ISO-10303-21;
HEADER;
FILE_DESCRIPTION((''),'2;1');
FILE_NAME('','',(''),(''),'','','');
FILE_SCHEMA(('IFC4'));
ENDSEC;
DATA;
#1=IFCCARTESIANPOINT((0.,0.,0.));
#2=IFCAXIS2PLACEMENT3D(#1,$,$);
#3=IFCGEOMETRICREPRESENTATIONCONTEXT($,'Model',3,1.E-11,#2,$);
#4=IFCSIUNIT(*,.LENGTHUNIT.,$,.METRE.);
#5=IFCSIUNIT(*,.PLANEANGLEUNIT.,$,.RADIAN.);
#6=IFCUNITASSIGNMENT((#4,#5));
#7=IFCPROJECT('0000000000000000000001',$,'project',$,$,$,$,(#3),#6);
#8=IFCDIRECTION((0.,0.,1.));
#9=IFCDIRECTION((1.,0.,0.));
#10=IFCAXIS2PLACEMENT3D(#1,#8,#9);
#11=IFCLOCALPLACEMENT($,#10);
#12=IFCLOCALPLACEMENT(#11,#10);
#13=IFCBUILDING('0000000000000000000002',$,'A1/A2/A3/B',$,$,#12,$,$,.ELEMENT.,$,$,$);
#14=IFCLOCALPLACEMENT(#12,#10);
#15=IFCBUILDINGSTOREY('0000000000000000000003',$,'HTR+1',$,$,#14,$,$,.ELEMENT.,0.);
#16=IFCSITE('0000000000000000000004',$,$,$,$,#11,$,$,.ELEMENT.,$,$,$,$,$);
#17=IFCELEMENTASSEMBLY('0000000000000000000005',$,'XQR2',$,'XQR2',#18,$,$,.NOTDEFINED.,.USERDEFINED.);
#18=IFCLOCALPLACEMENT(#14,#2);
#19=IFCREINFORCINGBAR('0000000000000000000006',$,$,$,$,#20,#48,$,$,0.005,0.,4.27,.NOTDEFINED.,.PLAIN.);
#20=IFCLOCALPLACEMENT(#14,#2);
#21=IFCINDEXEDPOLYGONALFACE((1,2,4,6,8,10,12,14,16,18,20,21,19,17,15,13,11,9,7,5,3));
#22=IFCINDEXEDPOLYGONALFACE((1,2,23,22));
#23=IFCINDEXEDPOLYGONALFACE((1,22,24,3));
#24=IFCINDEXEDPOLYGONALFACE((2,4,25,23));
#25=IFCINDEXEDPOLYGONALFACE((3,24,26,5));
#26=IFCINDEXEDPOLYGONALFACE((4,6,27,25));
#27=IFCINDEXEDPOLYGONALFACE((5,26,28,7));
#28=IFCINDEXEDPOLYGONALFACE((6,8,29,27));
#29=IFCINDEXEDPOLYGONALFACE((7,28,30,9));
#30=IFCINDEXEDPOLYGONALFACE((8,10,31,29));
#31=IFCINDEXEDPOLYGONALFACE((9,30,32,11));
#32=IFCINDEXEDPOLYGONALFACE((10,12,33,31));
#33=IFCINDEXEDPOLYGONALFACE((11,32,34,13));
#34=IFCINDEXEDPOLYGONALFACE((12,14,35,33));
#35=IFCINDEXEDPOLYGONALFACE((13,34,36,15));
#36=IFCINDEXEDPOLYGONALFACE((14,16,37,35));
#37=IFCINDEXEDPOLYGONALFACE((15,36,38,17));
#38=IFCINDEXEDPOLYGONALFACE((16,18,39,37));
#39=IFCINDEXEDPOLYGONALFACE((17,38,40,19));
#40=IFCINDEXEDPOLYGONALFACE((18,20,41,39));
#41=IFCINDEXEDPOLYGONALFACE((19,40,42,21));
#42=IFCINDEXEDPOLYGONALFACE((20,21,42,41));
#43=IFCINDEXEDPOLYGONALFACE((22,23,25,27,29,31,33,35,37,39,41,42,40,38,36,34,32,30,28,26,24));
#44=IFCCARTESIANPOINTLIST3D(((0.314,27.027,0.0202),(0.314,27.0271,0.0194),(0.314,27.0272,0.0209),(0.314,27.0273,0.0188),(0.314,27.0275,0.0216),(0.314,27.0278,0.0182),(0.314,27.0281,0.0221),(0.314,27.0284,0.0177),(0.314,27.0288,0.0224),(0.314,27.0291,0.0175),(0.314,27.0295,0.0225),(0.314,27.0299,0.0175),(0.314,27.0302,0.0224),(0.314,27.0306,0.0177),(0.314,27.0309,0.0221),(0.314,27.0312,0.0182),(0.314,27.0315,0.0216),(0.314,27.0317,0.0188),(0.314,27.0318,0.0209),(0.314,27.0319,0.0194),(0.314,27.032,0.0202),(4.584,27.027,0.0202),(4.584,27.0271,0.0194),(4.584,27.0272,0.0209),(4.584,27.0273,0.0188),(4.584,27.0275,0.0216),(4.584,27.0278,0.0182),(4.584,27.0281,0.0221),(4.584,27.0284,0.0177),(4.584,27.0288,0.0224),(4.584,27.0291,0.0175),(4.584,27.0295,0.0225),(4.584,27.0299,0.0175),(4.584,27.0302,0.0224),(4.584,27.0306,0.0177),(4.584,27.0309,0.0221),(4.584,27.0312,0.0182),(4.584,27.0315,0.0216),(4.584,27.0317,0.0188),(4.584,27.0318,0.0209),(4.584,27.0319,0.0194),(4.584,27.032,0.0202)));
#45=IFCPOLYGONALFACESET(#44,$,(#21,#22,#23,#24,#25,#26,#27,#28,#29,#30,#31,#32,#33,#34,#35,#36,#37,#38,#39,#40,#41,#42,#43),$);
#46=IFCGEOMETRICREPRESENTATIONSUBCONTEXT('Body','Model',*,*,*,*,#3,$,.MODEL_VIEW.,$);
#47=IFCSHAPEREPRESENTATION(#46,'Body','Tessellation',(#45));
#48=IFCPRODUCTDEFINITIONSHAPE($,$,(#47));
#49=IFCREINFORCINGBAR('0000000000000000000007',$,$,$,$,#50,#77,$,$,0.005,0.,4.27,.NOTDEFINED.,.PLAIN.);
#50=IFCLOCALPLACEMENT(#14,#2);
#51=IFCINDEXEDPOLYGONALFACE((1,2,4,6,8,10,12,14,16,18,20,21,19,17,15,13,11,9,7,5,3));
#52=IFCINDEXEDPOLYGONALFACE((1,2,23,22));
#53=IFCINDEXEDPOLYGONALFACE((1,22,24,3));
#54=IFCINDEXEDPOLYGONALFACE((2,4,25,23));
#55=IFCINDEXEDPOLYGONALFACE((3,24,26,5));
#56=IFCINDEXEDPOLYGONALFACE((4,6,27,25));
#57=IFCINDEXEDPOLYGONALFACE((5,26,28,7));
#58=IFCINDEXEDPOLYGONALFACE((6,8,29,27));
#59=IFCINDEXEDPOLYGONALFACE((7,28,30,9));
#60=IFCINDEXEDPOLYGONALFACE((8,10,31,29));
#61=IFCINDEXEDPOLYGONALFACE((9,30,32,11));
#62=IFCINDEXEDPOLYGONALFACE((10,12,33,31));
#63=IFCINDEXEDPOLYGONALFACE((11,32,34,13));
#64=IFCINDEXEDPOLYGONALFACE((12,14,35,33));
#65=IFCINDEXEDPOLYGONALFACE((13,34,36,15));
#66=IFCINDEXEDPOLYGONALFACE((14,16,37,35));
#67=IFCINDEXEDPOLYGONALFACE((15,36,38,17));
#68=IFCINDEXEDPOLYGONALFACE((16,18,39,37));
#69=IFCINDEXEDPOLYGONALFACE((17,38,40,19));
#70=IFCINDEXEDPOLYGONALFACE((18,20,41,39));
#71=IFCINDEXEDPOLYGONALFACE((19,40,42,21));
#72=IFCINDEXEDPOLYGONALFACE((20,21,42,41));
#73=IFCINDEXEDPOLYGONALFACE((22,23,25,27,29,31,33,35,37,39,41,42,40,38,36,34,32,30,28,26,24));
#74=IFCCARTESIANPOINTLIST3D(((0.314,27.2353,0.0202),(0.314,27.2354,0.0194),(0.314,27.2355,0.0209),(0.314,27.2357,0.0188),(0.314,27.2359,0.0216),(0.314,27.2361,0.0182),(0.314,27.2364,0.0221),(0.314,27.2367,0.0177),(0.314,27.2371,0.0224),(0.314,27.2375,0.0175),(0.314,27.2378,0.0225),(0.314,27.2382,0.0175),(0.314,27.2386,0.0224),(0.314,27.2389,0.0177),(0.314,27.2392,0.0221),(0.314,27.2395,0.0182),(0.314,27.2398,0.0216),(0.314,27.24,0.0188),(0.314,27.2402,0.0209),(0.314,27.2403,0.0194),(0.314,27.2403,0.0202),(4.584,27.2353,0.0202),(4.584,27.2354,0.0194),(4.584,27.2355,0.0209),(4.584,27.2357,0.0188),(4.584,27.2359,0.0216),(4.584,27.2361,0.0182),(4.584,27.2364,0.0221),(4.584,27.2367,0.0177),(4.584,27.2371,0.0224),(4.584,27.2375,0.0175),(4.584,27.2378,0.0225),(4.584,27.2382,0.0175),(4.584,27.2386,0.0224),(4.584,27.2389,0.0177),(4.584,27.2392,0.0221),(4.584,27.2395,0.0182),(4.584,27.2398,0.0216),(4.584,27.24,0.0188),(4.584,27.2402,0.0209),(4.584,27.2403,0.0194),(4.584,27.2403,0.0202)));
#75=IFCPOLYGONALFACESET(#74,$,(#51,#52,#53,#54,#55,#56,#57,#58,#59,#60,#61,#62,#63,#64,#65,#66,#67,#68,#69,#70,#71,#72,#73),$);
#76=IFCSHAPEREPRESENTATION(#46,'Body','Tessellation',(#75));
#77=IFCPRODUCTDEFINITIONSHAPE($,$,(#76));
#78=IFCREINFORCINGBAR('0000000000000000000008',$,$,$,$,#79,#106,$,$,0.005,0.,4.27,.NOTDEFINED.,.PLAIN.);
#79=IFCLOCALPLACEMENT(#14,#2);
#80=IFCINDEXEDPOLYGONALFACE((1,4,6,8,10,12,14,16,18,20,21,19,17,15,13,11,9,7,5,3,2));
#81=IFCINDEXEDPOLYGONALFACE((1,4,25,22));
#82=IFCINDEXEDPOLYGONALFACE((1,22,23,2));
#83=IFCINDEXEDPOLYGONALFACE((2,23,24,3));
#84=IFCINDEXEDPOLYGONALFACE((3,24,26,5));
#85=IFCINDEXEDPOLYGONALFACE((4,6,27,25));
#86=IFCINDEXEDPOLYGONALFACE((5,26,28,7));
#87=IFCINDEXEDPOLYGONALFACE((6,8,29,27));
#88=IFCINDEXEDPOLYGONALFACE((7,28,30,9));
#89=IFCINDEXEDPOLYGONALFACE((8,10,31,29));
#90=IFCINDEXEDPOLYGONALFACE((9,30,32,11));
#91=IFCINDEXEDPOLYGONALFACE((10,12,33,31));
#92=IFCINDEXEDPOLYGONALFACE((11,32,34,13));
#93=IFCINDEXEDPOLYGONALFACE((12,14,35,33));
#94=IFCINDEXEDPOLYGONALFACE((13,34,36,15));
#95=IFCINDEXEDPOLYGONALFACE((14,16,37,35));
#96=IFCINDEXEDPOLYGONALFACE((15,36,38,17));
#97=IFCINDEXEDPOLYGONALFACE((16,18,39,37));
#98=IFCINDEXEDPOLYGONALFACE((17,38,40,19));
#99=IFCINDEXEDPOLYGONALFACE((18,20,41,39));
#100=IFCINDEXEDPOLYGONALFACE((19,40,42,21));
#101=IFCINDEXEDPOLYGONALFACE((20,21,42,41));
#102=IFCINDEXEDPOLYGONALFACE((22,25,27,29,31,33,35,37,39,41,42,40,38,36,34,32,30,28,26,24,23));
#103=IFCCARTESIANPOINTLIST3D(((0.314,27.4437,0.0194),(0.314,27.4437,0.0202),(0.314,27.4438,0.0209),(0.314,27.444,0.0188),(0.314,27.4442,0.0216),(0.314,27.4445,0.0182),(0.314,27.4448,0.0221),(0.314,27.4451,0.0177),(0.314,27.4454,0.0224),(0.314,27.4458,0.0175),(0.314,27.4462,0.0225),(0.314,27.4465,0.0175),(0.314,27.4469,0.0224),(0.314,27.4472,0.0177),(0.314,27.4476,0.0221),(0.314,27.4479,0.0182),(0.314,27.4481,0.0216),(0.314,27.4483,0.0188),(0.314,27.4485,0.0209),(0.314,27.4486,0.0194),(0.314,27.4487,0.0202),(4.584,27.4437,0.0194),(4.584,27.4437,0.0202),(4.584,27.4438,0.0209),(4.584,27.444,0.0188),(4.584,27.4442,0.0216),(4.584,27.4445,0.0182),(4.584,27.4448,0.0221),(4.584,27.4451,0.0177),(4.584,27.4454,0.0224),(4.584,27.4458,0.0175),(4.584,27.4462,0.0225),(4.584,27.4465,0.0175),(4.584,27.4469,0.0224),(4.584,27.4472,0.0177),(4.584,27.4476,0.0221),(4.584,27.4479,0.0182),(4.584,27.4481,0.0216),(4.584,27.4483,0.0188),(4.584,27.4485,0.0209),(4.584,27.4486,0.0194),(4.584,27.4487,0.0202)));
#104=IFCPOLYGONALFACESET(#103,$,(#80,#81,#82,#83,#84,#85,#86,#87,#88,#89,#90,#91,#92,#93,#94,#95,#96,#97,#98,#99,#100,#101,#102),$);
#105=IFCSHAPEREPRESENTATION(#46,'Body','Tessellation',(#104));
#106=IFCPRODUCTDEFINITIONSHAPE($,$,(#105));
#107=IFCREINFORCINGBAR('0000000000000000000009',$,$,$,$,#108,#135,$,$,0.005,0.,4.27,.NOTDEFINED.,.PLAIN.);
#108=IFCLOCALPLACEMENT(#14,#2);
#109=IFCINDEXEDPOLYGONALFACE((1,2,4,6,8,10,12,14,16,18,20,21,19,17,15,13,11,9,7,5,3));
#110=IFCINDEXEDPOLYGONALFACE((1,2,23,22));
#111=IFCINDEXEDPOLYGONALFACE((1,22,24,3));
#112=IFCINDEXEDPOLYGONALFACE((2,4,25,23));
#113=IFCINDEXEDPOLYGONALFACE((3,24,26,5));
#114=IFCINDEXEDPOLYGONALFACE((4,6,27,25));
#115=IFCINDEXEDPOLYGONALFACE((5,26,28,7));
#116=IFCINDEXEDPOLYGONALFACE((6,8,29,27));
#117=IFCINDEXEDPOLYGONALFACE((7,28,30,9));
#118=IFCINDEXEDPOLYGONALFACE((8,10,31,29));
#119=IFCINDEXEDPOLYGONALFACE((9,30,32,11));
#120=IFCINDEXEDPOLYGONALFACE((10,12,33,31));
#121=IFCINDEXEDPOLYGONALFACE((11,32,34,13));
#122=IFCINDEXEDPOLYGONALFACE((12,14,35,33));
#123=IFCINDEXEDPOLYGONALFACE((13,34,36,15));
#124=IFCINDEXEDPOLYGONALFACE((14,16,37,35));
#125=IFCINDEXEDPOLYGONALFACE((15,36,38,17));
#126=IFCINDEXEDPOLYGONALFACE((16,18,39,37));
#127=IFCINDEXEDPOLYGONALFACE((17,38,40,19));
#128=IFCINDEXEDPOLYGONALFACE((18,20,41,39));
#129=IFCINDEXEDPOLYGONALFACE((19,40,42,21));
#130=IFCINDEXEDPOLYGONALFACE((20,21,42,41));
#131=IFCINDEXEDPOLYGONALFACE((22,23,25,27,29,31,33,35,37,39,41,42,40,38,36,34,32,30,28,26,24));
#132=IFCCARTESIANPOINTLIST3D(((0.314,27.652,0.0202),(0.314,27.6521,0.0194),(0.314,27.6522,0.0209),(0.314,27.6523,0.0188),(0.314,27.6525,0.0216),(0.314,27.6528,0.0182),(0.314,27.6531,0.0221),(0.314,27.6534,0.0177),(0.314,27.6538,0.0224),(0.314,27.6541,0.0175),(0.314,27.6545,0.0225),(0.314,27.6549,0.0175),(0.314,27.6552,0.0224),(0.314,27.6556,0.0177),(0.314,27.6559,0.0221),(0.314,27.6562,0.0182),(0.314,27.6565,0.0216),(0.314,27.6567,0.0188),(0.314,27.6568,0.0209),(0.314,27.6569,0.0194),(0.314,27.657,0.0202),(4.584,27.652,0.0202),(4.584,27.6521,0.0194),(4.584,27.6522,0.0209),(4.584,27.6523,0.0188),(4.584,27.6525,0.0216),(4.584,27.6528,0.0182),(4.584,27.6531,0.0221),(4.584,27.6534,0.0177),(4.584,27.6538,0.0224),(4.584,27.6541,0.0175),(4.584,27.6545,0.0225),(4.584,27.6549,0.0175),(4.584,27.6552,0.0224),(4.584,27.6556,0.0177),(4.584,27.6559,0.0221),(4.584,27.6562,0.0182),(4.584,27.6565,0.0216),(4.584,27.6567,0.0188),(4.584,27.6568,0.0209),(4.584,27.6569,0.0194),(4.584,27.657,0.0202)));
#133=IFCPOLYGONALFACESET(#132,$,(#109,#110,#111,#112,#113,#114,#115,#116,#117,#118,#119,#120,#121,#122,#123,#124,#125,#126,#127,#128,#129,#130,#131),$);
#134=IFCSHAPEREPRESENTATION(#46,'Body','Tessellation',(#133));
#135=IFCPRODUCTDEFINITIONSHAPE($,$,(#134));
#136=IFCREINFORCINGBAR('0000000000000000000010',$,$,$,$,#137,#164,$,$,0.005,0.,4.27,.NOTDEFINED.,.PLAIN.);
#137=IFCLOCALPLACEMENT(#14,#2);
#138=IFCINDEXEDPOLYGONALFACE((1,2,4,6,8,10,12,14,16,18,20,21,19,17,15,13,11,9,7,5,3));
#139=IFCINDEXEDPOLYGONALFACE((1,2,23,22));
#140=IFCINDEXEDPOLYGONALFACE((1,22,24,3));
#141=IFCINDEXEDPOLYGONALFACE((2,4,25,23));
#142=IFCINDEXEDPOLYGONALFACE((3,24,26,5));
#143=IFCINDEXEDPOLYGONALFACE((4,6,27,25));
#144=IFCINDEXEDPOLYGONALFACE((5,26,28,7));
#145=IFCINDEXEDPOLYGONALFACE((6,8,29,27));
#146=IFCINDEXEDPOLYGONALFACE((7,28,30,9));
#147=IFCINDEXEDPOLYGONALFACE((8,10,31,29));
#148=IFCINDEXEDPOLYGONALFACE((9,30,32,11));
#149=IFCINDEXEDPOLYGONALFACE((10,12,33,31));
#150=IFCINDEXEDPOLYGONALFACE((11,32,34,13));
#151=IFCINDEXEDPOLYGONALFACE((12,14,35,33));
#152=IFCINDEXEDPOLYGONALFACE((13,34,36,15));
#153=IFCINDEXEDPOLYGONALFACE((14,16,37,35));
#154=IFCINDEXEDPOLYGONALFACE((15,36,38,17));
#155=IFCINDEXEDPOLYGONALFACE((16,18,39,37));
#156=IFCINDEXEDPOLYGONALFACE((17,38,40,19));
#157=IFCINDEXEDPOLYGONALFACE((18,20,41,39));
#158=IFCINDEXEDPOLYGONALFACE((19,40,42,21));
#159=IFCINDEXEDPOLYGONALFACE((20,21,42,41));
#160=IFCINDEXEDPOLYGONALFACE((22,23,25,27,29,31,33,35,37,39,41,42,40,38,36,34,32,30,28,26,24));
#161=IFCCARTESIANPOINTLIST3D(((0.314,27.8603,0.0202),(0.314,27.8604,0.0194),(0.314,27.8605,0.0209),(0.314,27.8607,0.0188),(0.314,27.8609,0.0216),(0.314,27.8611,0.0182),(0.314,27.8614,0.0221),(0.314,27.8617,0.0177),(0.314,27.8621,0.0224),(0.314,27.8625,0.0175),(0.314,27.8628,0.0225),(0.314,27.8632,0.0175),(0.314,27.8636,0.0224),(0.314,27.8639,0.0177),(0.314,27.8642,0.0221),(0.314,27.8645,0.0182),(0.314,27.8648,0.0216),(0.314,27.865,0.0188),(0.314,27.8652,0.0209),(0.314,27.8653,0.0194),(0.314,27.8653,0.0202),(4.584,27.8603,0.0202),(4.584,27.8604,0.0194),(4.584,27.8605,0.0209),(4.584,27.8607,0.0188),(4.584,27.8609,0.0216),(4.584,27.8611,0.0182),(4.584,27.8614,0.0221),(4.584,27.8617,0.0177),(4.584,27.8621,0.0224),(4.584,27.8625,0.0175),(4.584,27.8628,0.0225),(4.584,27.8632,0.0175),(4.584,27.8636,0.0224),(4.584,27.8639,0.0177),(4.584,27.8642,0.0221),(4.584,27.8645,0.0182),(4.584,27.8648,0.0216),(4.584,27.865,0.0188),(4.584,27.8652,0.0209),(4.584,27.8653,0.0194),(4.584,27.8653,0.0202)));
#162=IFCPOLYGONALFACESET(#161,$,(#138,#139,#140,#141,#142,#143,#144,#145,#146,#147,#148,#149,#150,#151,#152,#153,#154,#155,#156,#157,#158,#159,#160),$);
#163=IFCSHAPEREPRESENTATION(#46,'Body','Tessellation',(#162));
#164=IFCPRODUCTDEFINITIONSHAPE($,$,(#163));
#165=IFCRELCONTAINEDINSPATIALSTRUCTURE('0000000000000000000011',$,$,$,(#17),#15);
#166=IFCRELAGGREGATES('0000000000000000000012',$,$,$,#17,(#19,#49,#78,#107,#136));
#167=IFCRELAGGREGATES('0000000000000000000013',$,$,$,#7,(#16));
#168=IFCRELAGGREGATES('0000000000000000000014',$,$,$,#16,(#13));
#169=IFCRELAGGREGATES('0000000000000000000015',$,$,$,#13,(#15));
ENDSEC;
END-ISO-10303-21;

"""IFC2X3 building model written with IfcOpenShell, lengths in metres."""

from ifc_helpers import new_model, entity, si_unit, origin, origin_with_axes, place, context, subcontext, project, spatial, shape, element, aggregate, save


model = new_model("IFC2X3")

# Units and contexts
model_context = context("Model", 3, precision=1e-11, world=origin())
body_context = subcontext(model_context, "Body", "Model", "MODEL_VIEW")
ifc_project = project(units=[si_unit("LENGTHUNIT", "METRE"), si_unit("PLANEANGLEUNIT", "RADIAN")], contexts=[model_context])

# Site, building, storey
site_placement = place(None, origin_with_axes())
site = spatial("IfcSite", under=ifc_project, at=site_placement, CompositionType="ELEMENT")
building_placement = place(site_placement, origin_with_axes())
building = spatial("IfcBuilding", under=site, at=building_placement, Name="A1/A2/A3/B", CompositionType="ELEMENT")
storey_placement = place(building_placement, origin_with_axes())
storey = spatial("IfcBuildingStorey", under=building, at=storey_placement, Name="HTR+1", CompositionType="ELEMENT", Elevation=0.0)

# Element assembly, reinforcing bars
assembly_1_placement = place(storey_placement, origin_with_axes())
assembly_1 = element("IfcElementAssembly", 1, at=assembly_1_placement, inside=storey, Name="XQR2", ObjectType="XQR2", AssemblyPlace="NOTDEFINED", PredefinedType="USERDEFINED")
reinforcing_bar_1_placement = place(assembly_1_placement, origin_with_axes())
reinforcing_bar_1 = element("IfcReinforcingBar", 2, at=reinforcing_bar_1_placement, BarLength=4.27, BarRole="NOTDEFINED", BarSurface="PLAIN", CrossSectionArea=0.0, NominalDiameter=0.005, shapes=[
    shape(body_context, "Body", "AdvancedSweptSolid", [entity("IfcSweptDiskSolid", entity("IfcPolyline", [entity("IfcCartesianPoint", [0.314, 27.0295, 0.02]), entity("IfcCartesianPoint", [4.584, 27.0295, 0.02])]), 0.0025, None, 0.0, 4.27)]),
    shape(body_context, "Body", "AdvancedSweptSolid", [entity("IfcSweptDiskSolid", entity("IfcPolyline", [entity("IfcCartesianPoint", [0.314, 27.0295, 0.02]), entity("IfcCartesianPoint", [4.584, 27.0295, 0.02])]), 0.0025, None, 0.0, 4.27)]),
])
reinforcing_bar_2_placement = place(assembly_1_placement, origin_with_axes())
reinforcing_bar_2 = element("IfcReinforcingBar", 3, at=reinforcing_bar_2_placement, BarLength=4.27, BarRole="NOTDEFINED", BarSurface="PLAIN", CrossSectionArea=0.0, NominalDiameter=0.005, shapes=[
    shape(body_context, "Body", "AdvancedSweptSolid", [entity("IfcSweptDiskSolid", entity("IfcPolyline", [entity("IfcCartesianPoint", [0.314, 27.2378, 0.02]), entity("IfcCartesianPoint", [4.584, 27.2378, 0.02])]), 0.0025, None, 0.0, 4.27)]),
    shape(body_context, "Body", "AdvancedSweptSolid", [entity("IfcSweptDiskSolid", entity("IfcPolyline", [entity("IfcCartesianPoint", [0.314, 27.2378, 0.02]), entity("IfcCartesianPoint", [4.584, 27.2378, 0.02])]), 0.0025, None, 0.0, 4.27)]),
])
reinforcing_bar_3_placement = place(assembly_1_placement, origin_with_axes())
reinforcing_bar_3 = element("IfcReinforcingBar", 4, at=reinforcing_bar_3_placement, BarLength=4.27, BarRole="NOTDEFINED", BarSurface="PLAIN", CrossSectionArea=0.0, NominalDiameter=0.005, shapes=[
    shape(body_context, "Body", "AdvancedSweptSolid", [entity("IfcSweptDiskSolid", entity("IfcPolyline", [entity("IfcCartesianPoint", [0.314, 27.4462, 0.02]), entity("IfcCartesianPoint", [4.584, 27.4462, 0.02])]), 0.0025, None, 0.0, 4.27)]),
    shape(body_context, "Body", "AdvancedSweptSolid", [entity("IfcSweptDiskSolid", entity("IfcPolyline", [entity("IfcCartesianPoint", [0.314, 27.4462, 0.02]), entity("IfcCartesianPoint", [4.584, 27.4462, 0.02])]), 0.0025, None, 0.0, 4.27)]),
])
reinforcing_bar_4_placement = place(assembly_1_placement, origin_with_axes())
reinforcing_bar_4 = element("IfcReinforcingBar", 5, at=reinforcing_bar_4_placement, BarLength=4.27, BarRole="NOTDEFINED", BarSurface="PLAIN", CrossSectionArea=0.0, NominalDiameter=0.005, shapes=[
    shape(body_context, "Body", "AdvancedSweptSolid", [entity("IfcSweptDiskSolid", entity("IfcPolyline", [entity("IfcCartesianPoint", [0.314, 27.6545, 0.02]), entity("IfcCartesianPoint", [4.584, 27.6545, 0.02])]), 0.0025, None, 0.0, 4.27)]),
    shape(body_context, "Body", "AdvancedSweptSolid", [entity("IfcSweptDiskSolid", entity("IfcPolyline", [entity("IfcCartesianPoint", [0.314, 27.6545, 0.02]), entity("IfcCartesianPoint", [4.584, 27.6545, 0.02])]), 0.0025, None, 0.0, 4.27)]),
])
reinforcing_bar_5_placement = place(assembly_1_placement, origin_with_axes())
reinforcing_bar_5 = element("IfcReinforcingBar", 6, at=reinforcing_bar_5_placement, BarLength=4.27, BarRole="NOTDEFINED", BarSurface="PLAIN", CrossSectionArea=0.0, NominalDiameter=0.005, shapes=[
    shape(body_context, "Body", "AdvancedSweptSolid", [entity("IfcSweptDiskSolid", entity("IfcPolyline", [entity("IfcCartesianPoint", [0.314, 27.8628, 0.02]), entity("IfcCartesianPoint", [4.584, 27.8628, 0.02])]), 0.0025, None, 0.0, 4.27)]),
    shape(body_context, "Body", "AdvancedSweptSolid", [entity("IfcSweptDiskSolid", entity("IfcPolyline", [entity("IfcCartesianPoint", [0.314, 27.8628, 0.02]), entity("IfcCartesianPoint", [4.584, 27.8628, 0.02])]), 0.0025, None, 0.0, 4.27)]),
])
aggregate(assembly_1, [reinforcing_bar_1, reinforcing_bar_2, reinforcing_bar_3, reinforcing_bar_4, reinforcing_bar_5])

save(model, "model.ifc")
